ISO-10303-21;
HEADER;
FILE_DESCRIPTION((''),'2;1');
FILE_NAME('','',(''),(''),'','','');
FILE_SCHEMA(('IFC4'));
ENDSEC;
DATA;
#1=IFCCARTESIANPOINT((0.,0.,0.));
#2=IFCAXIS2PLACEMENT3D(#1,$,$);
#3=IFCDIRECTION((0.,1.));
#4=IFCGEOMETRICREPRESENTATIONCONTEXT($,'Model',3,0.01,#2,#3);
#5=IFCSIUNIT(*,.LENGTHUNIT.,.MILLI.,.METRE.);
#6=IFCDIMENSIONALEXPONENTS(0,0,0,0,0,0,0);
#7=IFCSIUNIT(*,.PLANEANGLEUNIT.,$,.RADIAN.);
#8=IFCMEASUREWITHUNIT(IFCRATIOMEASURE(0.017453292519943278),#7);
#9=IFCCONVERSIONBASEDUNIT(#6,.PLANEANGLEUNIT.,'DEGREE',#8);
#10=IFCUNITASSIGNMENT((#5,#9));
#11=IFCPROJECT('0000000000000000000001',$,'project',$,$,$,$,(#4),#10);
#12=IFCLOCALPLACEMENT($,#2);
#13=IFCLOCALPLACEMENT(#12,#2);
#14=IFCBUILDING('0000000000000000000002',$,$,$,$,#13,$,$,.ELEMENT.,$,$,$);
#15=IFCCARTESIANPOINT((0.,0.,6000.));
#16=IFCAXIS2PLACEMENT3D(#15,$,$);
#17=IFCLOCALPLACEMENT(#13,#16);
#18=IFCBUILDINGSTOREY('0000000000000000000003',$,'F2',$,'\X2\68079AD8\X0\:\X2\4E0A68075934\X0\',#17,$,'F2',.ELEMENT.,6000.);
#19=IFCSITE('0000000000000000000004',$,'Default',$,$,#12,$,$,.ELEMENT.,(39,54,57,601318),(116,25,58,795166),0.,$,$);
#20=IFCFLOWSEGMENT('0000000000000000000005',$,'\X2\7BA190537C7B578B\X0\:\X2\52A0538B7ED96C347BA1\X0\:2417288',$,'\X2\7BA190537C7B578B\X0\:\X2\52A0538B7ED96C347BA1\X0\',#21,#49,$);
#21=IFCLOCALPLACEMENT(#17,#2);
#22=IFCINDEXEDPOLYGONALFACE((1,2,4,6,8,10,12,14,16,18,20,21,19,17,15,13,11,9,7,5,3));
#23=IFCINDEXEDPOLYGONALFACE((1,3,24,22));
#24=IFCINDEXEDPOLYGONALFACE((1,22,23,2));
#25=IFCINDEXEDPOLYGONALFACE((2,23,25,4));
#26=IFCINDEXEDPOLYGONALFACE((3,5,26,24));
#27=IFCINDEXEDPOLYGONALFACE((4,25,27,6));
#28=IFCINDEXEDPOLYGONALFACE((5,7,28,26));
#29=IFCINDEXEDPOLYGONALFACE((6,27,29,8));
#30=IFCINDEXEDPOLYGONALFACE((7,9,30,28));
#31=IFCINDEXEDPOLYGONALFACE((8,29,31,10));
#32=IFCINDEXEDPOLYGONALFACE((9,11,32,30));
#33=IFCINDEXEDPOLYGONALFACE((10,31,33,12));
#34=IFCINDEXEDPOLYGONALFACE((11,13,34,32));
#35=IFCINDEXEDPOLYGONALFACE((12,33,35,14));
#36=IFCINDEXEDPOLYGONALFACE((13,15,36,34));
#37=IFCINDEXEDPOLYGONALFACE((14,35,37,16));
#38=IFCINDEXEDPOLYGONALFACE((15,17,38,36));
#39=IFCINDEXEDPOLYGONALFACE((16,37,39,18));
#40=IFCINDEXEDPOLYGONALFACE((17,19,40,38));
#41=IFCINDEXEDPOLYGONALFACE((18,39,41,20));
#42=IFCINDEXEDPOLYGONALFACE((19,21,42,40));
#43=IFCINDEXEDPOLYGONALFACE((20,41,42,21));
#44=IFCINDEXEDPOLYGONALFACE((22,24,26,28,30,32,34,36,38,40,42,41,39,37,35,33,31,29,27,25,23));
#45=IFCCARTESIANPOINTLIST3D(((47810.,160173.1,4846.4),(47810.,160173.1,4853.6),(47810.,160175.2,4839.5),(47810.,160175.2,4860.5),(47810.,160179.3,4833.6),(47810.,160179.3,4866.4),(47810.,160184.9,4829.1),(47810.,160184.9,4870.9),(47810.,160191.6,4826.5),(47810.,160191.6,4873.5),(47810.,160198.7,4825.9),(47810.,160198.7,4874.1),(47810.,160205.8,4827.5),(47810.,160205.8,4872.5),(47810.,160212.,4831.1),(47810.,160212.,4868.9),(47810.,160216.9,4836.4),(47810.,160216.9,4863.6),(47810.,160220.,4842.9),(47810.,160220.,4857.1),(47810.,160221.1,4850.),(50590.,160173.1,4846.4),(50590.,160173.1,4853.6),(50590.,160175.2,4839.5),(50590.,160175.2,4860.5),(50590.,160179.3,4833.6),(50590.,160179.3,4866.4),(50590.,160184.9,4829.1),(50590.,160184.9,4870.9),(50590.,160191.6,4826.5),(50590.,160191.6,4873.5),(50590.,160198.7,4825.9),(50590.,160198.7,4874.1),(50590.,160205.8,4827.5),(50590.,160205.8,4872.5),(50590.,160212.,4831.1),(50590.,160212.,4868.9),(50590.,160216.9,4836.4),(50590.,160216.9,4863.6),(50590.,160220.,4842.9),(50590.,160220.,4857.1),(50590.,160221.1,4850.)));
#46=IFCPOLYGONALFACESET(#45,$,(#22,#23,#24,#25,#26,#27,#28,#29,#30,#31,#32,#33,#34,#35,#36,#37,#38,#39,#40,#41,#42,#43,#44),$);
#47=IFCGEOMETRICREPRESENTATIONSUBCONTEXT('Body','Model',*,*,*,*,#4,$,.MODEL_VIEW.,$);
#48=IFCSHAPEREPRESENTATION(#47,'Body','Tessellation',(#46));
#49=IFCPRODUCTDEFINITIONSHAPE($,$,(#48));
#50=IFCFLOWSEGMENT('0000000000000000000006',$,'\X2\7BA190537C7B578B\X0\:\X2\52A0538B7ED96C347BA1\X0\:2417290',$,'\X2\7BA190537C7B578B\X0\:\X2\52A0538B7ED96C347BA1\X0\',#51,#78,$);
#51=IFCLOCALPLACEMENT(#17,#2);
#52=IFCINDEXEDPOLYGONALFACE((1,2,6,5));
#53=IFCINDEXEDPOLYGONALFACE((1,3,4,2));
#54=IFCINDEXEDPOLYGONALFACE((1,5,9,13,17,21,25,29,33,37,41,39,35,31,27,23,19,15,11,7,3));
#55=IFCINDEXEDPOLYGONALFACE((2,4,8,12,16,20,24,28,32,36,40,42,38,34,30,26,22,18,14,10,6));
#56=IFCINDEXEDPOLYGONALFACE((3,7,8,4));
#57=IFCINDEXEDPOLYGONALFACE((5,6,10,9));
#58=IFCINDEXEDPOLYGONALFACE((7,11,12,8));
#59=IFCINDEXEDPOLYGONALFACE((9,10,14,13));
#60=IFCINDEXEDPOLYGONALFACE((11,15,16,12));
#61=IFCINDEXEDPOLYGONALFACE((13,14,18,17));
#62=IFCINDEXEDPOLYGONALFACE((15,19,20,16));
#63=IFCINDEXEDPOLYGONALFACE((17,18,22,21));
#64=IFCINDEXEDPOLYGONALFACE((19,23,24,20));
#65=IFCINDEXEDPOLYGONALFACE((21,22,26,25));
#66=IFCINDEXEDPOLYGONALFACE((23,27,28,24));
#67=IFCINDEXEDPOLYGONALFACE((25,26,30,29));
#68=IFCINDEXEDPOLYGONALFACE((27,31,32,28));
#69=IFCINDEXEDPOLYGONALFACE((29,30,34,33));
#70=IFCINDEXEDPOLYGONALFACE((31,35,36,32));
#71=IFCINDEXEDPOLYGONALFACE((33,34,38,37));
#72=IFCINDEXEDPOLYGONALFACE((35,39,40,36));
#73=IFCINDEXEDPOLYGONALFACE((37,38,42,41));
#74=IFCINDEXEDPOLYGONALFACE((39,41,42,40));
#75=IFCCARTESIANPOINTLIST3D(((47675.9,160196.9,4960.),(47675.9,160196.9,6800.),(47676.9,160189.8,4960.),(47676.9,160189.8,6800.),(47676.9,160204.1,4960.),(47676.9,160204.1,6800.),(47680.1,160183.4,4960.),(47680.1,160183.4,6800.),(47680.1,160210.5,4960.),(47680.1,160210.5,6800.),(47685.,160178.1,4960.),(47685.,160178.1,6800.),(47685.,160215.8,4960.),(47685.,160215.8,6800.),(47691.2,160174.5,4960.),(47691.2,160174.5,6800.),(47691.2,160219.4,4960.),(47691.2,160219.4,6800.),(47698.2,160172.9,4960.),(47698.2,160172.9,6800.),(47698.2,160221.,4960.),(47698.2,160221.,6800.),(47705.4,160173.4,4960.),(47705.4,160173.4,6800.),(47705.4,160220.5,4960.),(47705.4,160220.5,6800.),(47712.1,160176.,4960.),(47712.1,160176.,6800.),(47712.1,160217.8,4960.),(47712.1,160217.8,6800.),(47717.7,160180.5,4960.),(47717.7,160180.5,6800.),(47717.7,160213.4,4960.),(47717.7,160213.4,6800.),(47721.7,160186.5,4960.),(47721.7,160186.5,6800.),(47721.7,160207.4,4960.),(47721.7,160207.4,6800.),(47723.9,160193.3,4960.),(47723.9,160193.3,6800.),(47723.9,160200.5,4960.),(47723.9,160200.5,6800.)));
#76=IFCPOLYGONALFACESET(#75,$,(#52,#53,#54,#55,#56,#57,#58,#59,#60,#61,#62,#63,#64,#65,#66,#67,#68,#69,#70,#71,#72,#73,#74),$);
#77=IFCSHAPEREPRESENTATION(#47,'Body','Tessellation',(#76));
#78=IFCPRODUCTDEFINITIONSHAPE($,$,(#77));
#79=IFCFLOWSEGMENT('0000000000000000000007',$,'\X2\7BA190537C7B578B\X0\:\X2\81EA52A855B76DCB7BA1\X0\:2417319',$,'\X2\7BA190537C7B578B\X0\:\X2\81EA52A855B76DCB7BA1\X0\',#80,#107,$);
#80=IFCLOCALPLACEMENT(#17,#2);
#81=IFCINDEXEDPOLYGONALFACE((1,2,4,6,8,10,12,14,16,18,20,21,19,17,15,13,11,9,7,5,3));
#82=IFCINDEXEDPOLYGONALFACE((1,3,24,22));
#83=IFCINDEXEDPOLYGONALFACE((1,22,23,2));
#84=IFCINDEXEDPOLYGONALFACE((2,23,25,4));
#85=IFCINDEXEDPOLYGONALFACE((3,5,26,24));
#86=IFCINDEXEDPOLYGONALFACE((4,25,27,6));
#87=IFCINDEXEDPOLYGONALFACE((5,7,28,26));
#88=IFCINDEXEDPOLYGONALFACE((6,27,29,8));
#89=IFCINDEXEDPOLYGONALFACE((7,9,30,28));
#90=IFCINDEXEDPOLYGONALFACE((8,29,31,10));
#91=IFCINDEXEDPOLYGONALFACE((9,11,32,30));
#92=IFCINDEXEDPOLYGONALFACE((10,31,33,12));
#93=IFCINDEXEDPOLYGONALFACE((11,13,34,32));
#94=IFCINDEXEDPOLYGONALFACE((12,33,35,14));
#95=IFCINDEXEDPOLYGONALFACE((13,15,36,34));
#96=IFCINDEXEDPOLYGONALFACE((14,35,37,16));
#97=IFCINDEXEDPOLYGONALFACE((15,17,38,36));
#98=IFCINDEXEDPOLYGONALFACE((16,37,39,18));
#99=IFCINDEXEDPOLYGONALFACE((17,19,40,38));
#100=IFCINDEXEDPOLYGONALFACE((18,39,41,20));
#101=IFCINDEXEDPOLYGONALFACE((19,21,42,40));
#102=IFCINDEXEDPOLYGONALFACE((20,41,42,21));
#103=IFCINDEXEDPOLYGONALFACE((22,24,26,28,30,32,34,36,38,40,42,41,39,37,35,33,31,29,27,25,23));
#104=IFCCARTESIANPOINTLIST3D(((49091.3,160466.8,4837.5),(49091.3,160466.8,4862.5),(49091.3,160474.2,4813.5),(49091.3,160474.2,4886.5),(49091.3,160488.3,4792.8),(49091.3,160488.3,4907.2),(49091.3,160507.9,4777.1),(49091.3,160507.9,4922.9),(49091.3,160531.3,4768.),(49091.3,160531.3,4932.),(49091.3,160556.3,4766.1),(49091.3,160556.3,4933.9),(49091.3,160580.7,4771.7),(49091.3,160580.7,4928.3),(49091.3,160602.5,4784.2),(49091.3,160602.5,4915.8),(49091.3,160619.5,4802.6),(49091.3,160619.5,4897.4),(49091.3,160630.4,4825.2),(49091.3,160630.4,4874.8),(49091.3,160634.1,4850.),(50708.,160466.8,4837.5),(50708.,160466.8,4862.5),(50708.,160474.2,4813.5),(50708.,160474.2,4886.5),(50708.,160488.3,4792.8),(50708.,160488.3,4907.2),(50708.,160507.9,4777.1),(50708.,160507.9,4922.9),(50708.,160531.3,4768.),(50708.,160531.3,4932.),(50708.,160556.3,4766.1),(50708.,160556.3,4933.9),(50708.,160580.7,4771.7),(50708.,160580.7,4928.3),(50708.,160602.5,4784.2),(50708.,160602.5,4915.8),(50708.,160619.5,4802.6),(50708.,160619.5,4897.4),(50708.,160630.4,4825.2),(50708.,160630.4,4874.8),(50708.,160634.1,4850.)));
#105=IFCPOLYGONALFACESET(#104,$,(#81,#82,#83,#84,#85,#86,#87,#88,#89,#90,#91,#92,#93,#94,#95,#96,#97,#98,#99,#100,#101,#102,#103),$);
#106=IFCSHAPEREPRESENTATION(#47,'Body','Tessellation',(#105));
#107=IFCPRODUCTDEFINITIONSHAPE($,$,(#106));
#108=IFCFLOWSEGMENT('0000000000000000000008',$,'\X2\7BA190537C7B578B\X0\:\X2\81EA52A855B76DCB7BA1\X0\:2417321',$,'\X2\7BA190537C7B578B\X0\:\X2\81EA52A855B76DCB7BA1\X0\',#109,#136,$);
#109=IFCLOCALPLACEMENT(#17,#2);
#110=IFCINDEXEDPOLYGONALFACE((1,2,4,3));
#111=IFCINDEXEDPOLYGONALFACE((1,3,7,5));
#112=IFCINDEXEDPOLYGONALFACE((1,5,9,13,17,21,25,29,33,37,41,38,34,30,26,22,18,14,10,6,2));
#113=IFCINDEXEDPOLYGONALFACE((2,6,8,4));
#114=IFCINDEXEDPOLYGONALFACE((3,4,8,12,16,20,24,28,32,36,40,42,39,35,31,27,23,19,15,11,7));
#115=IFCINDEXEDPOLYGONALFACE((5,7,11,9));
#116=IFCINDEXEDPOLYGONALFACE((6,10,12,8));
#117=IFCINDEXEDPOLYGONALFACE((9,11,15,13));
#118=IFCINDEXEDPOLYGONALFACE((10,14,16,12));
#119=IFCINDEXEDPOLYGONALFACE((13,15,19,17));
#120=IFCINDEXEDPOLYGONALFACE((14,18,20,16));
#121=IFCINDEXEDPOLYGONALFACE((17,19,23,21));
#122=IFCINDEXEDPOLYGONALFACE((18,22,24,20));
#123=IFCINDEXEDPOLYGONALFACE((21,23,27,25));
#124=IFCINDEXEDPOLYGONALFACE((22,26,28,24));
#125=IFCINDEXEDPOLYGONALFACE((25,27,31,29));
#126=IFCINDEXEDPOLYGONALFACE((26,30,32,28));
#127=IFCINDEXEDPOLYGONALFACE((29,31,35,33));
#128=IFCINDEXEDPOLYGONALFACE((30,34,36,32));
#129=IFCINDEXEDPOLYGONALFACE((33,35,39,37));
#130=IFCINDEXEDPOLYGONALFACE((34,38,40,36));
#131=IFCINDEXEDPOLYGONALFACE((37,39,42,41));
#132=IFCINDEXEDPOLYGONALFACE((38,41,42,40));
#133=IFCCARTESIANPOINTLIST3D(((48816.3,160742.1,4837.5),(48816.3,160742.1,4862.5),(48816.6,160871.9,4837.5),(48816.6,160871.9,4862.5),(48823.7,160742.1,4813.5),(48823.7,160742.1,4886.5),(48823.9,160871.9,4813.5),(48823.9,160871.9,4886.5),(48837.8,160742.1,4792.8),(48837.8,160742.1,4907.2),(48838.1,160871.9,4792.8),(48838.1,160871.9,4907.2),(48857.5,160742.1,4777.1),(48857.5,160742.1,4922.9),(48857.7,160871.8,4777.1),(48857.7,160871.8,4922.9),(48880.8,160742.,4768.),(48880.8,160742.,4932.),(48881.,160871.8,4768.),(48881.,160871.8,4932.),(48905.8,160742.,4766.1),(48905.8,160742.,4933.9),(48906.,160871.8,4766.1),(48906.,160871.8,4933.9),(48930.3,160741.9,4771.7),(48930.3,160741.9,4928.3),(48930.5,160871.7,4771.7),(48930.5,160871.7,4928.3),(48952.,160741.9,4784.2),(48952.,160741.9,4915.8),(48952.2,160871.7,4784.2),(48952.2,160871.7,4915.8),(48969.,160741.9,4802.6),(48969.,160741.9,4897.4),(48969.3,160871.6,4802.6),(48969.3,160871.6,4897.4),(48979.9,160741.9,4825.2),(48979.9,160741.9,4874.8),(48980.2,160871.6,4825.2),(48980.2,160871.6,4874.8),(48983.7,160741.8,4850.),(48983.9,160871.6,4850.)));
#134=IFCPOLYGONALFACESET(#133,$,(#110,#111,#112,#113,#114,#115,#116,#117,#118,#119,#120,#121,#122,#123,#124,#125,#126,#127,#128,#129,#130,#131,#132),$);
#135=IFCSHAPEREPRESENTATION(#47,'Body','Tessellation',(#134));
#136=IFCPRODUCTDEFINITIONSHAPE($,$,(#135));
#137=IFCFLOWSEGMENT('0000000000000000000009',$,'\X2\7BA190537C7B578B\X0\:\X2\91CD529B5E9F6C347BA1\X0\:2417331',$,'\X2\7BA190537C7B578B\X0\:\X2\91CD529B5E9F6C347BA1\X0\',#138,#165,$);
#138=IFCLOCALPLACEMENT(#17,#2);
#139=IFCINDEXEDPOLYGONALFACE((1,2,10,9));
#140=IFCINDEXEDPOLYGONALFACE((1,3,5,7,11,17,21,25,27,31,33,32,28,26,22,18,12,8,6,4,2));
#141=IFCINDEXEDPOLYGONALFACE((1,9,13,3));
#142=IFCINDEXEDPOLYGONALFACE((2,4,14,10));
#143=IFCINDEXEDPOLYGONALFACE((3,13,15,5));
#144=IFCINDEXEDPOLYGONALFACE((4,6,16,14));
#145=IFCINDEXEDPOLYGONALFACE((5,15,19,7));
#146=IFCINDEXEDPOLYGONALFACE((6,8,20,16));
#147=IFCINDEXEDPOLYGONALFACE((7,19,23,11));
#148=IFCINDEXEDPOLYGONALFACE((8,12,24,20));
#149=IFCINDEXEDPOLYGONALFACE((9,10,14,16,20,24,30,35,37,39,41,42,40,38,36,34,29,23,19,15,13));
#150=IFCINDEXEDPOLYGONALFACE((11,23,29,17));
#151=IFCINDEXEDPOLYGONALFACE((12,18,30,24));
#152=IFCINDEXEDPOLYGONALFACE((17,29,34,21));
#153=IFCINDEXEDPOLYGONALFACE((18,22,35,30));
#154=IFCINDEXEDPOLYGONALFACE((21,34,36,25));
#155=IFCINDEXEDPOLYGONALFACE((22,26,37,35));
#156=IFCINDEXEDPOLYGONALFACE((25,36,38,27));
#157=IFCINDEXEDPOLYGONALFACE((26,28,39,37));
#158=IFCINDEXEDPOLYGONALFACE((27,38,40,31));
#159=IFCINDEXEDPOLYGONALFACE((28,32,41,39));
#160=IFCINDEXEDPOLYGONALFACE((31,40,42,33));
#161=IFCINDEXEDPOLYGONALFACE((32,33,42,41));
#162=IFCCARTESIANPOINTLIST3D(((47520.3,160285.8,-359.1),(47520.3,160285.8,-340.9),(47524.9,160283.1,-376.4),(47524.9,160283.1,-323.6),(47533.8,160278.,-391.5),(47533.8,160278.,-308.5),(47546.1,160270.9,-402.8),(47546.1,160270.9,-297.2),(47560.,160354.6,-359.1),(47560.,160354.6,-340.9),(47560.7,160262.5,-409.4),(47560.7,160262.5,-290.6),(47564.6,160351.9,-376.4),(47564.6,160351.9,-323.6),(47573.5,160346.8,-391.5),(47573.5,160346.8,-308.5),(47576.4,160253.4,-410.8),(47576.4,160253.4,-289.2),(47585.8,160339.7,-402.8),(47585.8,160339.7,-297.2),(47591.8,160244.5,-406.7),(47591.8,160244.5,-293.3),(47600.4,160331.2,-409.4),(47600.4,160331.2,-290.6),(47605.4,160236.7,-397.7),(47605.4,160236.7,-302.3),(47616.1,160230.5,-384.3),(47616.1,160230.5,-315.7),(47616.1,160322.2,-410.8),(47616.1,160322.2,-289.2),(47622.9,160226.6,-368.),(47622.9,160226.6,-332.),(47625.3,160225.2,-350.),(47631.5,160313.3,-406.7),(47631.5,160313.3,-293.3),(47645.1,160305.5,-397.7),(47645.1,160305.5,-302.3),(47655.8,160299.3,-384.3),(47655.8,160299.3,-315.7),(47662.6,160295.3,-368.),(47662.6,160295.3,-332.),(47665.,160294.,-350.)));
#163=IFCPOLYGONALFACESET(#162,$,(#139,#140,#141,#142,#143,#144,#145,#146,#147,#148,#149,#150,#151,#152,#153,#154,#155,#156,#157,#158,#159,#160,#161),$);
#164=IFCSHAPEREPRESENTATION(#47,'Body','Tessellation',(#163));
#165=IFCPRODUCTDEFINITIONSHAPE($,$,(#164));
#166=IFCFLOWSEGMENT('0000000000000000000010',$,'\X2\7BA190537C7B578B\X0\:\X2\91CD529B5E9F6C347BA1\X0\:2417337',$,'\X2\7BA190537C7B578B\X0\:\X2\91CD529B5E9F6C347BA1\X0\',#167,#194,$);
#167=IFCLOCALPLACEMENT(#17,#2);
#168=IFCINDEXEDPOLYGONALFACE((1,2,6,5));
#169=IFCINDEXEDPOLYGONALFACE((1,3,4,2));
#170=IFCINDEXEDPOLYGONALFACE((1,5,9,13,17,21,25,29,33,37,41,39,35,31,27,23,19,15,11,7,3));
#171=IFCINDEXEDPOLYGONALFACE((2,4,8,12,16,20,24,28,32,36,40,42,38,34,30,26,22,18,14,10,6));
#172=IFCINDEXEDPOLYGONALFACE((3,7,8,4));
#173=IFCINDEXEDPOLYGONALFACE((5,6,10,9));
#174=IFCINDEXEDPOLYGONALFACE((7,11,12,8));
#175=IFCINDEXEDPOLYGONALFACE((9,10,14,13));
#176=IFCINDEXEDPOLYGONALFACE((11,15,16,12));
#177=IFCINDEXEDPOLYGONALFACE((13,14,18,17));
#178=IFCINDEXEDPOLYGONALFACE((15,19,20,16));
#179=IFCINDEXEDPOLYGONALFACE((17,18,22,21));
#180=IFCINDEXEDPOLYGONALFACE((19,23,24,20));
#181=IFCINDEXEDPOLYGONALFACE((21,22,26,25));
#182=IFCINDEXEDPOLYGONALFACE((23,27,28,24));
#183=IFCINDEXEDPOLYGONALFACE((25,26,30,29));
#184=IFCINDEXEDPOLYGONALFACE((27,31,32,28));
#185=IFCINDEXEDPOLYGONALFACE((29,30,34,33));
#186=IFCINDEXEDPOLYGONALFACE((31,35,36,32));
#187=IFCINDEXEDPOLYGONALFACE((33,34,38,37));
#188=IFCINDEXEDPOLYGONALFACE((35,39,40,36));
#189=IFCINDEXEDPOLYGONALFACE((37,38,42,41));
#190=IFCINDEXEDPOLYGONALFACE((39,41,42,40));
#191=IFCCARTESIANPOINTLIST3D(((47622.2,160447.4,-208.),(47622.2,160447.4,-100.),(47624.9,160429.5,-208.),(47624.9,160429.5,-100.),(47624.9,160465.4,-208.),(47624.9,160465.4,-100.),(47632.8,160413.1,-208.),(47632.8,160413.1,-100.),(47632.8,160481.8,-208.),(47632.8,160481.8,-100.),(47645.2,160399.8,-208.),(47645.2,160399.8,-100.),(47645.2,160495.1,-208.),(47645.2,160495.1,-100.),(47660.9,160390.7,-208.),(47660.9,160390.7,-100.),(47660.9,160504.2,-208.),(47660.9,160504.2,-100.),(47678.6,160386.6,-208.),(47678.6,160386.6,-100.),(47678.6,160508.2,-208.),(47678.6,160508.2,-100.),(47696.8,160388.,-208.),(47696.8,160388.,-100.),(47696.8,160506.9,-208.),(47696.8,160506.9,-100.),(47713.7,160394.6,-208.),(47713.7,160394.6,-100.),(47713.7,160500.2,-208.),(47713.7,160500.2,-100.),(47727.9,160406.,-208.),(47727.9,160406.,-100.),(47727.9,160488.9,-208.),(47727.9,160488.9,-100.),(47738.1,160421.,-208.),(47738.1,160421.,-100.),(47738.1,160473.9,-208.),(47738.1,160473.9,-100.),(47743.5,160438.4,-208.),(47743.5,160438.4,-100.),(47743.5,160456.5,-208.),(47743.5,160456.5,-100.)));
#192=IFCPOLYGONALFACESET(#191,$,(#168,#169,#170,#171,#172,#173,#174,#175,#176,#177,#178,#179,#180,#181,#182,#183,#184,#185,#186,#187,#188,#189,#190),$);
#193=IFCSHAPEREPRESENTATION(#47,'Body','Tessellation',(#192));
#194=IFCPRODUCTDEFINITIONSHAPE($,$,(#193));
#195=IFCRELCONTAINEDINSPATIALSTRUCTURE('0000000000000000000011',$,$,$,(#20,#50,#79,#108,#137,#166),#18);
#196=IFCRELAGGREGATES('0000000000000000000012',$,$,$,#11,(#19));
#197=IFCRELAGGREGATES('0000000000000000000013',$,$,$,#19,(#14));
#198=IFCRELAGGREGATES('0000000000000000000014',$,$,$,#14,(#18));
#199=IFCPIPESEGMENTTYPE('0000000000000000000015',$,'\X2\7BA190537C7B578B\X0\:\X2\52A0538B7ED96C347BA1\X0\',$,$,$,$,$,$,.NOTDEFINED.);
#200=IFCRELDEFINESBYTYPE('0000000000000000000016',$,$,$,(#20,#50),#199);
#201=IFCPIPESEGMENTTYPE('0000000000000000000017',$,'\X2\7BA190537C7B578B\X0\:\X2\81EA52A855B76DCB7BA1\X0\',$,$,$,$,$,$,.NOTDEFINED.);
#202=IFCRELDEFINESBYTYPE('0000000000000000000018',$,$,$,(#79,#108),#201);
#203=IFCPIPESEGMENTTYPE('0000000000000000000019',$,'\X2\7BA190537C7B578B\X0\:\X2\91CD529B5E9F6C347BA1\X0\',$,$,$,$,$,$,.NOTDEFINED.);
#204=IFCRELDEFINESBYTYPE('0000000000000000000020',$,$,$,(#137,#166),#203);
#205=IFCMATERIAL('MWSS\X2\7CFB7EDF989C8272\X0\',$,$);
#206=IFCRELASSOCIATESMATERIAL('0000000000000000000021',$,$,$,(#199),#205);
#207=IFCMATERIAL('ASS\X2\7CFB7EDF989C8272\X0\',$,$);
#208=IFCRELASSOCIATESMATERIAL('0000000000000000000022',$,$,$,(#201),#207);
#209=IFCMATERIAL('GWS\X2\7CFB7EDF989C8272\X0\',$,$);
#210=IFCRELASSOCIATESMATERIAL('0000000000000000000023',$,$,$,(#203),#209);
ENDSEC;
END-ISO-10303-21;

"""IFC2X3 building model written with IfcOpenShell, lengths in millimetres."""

from ifc_helpers import new_model, entity, si_unit, converted_unit, direction, frame, frame_2d, origin, origin_2d_with_axis, place, context, subcontext, project, spatial, circle, extrude, material, type_object, element, save


model = new_model("IFC2X3")

# Units and contexts
model_context = context("Model", 3, precision=0.01, world=origin(), true_north=direction((0.0, 1.0)))
body_context = subcontext(model_context, "Body", "Model", "MODEL_VIEW")
ifc_project = project(units=[si_unit("LENGTHUNIT", "METRE", prefix="MILLI"), converted_unit("PLANEANGLEUNIT", "DEGREE", entity("IfcRatioMeasure", 0.017453292519943278), si_unit("PLANEANGLEUNIT", "RADIAN"), dimensions=[0, 0, 0, 0, 0, 0, 0])], contexts=[model_context])

# Site, building, storey
site_placement = place(None, origin())
site = spatial("IfcSite", under=ifc_project, at=site_placement, Name="Default", CompositionType="ELEMENT", RefLatitude=(39, 54, 57, 601318), RefLongitude=(116, 25, 58, 795166), RefElevation=0.0)
building_placement = place(site_placement, origin())
building = spatial("IfcBuilding", under=site, at=building_placement, CompositionType="ELEMENT")
storey_placement = place(building_placement, frame((0.0, 0.0, 6000.0)))
storey = spatial("IfcBuildingStorey", under=building, at=storey_placement, Name="F2", ObjectType="标高:上标头", LongName="F2", CompositionType="ELEMENT", Elevation=6000.0)

# Flow segments
ifc_material_1 = material(Name="MWSS系统颜色")
pipe_segment_type_1 = type_object("IfcPipeSegmentType", Name="管道类型:加压给水管", PredefinedType="NOTDEFINED", material=ifc_material_1)
flow_segment_1_placement = place(storey_placement, origin())
element("IfcFlowSegment", 1, at=flow_segment_1_placement, inside=storey, type_object=pipe_segment_type_1, Name="管道类型:加压给水管:2417288", ObjectType="管道类型:加压给水管", context=body_context, shape_type="SweptSolid", body=[
    extrude(circle(Radius=24.1, at=origin_2d_with_axis()), frame((47810.0, 160196.9, 4850.0), z_axis=(1.0, 0.0, 0.0), x_axis=(0.0, 1.0, 0.0)), (0.0, 0.0, 1.0), 2780.0),
])
flow_segment_2_placement = place(storey_placement, origin())
element("IfcFlowSegment", 2, at=flow_segment_2_placement, inside=storey, type_object=pipe_segment_type_1, Name="管道类型:加压给水管:2417290", ObjectType="管道类型:加压给水管", context=body_context, shape_type="SweptSolid", body=[
    extrude(circle(Radius=24.1, at=origin_2d_with_axis()), frame((47700.0, 160196.9, 4960.0), z_axis=(0.0, 0.0, 1.0), x_axis=(-1.0, 0.0, 0.0)), (0.0, 0.0, 1.0), 1840.0),
])
ifc_material_2 = material(Name="ASS系统颜色")
pipe_segment_type_2 = type_object("IfcPipeSegmentType", Name="管道类型:自动喷淋管", PredefinedType="NOTDEFINED", material=ifc_material_2)
flow_segment_3_placement = place(storey_placement, origin())
element("IfcFlowSegment", 3, at=flow_segment_3_placement, inside=storey, type_object=pipe_segment_type_2, Name="管道类型:自动喷淋管:2417319", ObjectType="管道类型:自动喷淋管", context=body_context, shape_type="SweptSolid", body=[
    extrude(circle(Radius=84.1, at=origin_2d_with_axis()), frame((49091.3, 160550.0, 4850.0), z_axis=(1.0, 0.0, 0.0), x_axis=(0.0, 1.0, 0.0)), (0.0, 0.0, 1.0), 1616.7),
])
flow_segment_4_placement = place(storey_placement, origin())
element("IfcFlowSegment", 4, at=flow_segment_4_placement, inside=storey, type_object=pipe_segment_type_2, Name="管道类型:自动喷淋管:2417321", ObjectType="管道类型:自动喷淋管", context=body_context, shape_type="SweptSolid", body=[
    extrude(circle(Radius=84.1, at=frame_2d((0.0, 0.0), x_axis=(1.0, 0.0))), frame((48899.5, 160742.0, 4850.0), z_axis=(0.001798, 0.999998, 0.0), x_axis=(0.999998, -0.001798, 0.0)), (0.0, 0.0, 1.0), 129.8),
])
ifc_material_3 = material(Name="GWS系统颜色")
pipe_segment_type_3 = type_object("IfcPipeSegmentType", Name="管道类型:重力废水管", PredefinedType="NOTDEFINED", material=ifc_material_3)
flow_segment_5_placement = place(storey_placement, origin())
element("IfcFlowSegment", 5, at=flow_segment_5_placement, inside=storey, type_object=pipe_segment_type_3, Name="管道类型:重力废水管:2417331", ObjectType="管道类型:重力废水管", context=body_context, shape_type="SweptSolid", body=[
    extrude(circle(Radius=61.0, at=frame_2d((0.0, 0.0), x_axis=(1.0, 0.0))), frame((47572.5, 160255.7, -350.0), z_axis=(0.5, 0.866025, 0.0), x_axis=(0.866025, -0.5, 0.0)), (0.0, 0.0, 1.0), 79.4),
])
flow_segment_6_placement = place(storey_placement, origin())
element("IfcFlowSegment", 6, at=flow_segment_6_placement, inside=storey, type_object=pipe_segment_type_3, Name="管道类型:重力废水管:2417337", ObjectType="管道类型:重力废水管", context=body_context, shape_type="SweptSolid", body=[
    extrude(circle(Radius=61.0, at=origin_2d_with_axis()), frame((47683.2, 160447.4, -208.0), z_axis=(0.0, 0.0, 1.0), x_axis=(-1.0, 0.0, 0.0)), (0.0, 0.0, 1.0), 108.0),
])

save(model, "model.ifc")
